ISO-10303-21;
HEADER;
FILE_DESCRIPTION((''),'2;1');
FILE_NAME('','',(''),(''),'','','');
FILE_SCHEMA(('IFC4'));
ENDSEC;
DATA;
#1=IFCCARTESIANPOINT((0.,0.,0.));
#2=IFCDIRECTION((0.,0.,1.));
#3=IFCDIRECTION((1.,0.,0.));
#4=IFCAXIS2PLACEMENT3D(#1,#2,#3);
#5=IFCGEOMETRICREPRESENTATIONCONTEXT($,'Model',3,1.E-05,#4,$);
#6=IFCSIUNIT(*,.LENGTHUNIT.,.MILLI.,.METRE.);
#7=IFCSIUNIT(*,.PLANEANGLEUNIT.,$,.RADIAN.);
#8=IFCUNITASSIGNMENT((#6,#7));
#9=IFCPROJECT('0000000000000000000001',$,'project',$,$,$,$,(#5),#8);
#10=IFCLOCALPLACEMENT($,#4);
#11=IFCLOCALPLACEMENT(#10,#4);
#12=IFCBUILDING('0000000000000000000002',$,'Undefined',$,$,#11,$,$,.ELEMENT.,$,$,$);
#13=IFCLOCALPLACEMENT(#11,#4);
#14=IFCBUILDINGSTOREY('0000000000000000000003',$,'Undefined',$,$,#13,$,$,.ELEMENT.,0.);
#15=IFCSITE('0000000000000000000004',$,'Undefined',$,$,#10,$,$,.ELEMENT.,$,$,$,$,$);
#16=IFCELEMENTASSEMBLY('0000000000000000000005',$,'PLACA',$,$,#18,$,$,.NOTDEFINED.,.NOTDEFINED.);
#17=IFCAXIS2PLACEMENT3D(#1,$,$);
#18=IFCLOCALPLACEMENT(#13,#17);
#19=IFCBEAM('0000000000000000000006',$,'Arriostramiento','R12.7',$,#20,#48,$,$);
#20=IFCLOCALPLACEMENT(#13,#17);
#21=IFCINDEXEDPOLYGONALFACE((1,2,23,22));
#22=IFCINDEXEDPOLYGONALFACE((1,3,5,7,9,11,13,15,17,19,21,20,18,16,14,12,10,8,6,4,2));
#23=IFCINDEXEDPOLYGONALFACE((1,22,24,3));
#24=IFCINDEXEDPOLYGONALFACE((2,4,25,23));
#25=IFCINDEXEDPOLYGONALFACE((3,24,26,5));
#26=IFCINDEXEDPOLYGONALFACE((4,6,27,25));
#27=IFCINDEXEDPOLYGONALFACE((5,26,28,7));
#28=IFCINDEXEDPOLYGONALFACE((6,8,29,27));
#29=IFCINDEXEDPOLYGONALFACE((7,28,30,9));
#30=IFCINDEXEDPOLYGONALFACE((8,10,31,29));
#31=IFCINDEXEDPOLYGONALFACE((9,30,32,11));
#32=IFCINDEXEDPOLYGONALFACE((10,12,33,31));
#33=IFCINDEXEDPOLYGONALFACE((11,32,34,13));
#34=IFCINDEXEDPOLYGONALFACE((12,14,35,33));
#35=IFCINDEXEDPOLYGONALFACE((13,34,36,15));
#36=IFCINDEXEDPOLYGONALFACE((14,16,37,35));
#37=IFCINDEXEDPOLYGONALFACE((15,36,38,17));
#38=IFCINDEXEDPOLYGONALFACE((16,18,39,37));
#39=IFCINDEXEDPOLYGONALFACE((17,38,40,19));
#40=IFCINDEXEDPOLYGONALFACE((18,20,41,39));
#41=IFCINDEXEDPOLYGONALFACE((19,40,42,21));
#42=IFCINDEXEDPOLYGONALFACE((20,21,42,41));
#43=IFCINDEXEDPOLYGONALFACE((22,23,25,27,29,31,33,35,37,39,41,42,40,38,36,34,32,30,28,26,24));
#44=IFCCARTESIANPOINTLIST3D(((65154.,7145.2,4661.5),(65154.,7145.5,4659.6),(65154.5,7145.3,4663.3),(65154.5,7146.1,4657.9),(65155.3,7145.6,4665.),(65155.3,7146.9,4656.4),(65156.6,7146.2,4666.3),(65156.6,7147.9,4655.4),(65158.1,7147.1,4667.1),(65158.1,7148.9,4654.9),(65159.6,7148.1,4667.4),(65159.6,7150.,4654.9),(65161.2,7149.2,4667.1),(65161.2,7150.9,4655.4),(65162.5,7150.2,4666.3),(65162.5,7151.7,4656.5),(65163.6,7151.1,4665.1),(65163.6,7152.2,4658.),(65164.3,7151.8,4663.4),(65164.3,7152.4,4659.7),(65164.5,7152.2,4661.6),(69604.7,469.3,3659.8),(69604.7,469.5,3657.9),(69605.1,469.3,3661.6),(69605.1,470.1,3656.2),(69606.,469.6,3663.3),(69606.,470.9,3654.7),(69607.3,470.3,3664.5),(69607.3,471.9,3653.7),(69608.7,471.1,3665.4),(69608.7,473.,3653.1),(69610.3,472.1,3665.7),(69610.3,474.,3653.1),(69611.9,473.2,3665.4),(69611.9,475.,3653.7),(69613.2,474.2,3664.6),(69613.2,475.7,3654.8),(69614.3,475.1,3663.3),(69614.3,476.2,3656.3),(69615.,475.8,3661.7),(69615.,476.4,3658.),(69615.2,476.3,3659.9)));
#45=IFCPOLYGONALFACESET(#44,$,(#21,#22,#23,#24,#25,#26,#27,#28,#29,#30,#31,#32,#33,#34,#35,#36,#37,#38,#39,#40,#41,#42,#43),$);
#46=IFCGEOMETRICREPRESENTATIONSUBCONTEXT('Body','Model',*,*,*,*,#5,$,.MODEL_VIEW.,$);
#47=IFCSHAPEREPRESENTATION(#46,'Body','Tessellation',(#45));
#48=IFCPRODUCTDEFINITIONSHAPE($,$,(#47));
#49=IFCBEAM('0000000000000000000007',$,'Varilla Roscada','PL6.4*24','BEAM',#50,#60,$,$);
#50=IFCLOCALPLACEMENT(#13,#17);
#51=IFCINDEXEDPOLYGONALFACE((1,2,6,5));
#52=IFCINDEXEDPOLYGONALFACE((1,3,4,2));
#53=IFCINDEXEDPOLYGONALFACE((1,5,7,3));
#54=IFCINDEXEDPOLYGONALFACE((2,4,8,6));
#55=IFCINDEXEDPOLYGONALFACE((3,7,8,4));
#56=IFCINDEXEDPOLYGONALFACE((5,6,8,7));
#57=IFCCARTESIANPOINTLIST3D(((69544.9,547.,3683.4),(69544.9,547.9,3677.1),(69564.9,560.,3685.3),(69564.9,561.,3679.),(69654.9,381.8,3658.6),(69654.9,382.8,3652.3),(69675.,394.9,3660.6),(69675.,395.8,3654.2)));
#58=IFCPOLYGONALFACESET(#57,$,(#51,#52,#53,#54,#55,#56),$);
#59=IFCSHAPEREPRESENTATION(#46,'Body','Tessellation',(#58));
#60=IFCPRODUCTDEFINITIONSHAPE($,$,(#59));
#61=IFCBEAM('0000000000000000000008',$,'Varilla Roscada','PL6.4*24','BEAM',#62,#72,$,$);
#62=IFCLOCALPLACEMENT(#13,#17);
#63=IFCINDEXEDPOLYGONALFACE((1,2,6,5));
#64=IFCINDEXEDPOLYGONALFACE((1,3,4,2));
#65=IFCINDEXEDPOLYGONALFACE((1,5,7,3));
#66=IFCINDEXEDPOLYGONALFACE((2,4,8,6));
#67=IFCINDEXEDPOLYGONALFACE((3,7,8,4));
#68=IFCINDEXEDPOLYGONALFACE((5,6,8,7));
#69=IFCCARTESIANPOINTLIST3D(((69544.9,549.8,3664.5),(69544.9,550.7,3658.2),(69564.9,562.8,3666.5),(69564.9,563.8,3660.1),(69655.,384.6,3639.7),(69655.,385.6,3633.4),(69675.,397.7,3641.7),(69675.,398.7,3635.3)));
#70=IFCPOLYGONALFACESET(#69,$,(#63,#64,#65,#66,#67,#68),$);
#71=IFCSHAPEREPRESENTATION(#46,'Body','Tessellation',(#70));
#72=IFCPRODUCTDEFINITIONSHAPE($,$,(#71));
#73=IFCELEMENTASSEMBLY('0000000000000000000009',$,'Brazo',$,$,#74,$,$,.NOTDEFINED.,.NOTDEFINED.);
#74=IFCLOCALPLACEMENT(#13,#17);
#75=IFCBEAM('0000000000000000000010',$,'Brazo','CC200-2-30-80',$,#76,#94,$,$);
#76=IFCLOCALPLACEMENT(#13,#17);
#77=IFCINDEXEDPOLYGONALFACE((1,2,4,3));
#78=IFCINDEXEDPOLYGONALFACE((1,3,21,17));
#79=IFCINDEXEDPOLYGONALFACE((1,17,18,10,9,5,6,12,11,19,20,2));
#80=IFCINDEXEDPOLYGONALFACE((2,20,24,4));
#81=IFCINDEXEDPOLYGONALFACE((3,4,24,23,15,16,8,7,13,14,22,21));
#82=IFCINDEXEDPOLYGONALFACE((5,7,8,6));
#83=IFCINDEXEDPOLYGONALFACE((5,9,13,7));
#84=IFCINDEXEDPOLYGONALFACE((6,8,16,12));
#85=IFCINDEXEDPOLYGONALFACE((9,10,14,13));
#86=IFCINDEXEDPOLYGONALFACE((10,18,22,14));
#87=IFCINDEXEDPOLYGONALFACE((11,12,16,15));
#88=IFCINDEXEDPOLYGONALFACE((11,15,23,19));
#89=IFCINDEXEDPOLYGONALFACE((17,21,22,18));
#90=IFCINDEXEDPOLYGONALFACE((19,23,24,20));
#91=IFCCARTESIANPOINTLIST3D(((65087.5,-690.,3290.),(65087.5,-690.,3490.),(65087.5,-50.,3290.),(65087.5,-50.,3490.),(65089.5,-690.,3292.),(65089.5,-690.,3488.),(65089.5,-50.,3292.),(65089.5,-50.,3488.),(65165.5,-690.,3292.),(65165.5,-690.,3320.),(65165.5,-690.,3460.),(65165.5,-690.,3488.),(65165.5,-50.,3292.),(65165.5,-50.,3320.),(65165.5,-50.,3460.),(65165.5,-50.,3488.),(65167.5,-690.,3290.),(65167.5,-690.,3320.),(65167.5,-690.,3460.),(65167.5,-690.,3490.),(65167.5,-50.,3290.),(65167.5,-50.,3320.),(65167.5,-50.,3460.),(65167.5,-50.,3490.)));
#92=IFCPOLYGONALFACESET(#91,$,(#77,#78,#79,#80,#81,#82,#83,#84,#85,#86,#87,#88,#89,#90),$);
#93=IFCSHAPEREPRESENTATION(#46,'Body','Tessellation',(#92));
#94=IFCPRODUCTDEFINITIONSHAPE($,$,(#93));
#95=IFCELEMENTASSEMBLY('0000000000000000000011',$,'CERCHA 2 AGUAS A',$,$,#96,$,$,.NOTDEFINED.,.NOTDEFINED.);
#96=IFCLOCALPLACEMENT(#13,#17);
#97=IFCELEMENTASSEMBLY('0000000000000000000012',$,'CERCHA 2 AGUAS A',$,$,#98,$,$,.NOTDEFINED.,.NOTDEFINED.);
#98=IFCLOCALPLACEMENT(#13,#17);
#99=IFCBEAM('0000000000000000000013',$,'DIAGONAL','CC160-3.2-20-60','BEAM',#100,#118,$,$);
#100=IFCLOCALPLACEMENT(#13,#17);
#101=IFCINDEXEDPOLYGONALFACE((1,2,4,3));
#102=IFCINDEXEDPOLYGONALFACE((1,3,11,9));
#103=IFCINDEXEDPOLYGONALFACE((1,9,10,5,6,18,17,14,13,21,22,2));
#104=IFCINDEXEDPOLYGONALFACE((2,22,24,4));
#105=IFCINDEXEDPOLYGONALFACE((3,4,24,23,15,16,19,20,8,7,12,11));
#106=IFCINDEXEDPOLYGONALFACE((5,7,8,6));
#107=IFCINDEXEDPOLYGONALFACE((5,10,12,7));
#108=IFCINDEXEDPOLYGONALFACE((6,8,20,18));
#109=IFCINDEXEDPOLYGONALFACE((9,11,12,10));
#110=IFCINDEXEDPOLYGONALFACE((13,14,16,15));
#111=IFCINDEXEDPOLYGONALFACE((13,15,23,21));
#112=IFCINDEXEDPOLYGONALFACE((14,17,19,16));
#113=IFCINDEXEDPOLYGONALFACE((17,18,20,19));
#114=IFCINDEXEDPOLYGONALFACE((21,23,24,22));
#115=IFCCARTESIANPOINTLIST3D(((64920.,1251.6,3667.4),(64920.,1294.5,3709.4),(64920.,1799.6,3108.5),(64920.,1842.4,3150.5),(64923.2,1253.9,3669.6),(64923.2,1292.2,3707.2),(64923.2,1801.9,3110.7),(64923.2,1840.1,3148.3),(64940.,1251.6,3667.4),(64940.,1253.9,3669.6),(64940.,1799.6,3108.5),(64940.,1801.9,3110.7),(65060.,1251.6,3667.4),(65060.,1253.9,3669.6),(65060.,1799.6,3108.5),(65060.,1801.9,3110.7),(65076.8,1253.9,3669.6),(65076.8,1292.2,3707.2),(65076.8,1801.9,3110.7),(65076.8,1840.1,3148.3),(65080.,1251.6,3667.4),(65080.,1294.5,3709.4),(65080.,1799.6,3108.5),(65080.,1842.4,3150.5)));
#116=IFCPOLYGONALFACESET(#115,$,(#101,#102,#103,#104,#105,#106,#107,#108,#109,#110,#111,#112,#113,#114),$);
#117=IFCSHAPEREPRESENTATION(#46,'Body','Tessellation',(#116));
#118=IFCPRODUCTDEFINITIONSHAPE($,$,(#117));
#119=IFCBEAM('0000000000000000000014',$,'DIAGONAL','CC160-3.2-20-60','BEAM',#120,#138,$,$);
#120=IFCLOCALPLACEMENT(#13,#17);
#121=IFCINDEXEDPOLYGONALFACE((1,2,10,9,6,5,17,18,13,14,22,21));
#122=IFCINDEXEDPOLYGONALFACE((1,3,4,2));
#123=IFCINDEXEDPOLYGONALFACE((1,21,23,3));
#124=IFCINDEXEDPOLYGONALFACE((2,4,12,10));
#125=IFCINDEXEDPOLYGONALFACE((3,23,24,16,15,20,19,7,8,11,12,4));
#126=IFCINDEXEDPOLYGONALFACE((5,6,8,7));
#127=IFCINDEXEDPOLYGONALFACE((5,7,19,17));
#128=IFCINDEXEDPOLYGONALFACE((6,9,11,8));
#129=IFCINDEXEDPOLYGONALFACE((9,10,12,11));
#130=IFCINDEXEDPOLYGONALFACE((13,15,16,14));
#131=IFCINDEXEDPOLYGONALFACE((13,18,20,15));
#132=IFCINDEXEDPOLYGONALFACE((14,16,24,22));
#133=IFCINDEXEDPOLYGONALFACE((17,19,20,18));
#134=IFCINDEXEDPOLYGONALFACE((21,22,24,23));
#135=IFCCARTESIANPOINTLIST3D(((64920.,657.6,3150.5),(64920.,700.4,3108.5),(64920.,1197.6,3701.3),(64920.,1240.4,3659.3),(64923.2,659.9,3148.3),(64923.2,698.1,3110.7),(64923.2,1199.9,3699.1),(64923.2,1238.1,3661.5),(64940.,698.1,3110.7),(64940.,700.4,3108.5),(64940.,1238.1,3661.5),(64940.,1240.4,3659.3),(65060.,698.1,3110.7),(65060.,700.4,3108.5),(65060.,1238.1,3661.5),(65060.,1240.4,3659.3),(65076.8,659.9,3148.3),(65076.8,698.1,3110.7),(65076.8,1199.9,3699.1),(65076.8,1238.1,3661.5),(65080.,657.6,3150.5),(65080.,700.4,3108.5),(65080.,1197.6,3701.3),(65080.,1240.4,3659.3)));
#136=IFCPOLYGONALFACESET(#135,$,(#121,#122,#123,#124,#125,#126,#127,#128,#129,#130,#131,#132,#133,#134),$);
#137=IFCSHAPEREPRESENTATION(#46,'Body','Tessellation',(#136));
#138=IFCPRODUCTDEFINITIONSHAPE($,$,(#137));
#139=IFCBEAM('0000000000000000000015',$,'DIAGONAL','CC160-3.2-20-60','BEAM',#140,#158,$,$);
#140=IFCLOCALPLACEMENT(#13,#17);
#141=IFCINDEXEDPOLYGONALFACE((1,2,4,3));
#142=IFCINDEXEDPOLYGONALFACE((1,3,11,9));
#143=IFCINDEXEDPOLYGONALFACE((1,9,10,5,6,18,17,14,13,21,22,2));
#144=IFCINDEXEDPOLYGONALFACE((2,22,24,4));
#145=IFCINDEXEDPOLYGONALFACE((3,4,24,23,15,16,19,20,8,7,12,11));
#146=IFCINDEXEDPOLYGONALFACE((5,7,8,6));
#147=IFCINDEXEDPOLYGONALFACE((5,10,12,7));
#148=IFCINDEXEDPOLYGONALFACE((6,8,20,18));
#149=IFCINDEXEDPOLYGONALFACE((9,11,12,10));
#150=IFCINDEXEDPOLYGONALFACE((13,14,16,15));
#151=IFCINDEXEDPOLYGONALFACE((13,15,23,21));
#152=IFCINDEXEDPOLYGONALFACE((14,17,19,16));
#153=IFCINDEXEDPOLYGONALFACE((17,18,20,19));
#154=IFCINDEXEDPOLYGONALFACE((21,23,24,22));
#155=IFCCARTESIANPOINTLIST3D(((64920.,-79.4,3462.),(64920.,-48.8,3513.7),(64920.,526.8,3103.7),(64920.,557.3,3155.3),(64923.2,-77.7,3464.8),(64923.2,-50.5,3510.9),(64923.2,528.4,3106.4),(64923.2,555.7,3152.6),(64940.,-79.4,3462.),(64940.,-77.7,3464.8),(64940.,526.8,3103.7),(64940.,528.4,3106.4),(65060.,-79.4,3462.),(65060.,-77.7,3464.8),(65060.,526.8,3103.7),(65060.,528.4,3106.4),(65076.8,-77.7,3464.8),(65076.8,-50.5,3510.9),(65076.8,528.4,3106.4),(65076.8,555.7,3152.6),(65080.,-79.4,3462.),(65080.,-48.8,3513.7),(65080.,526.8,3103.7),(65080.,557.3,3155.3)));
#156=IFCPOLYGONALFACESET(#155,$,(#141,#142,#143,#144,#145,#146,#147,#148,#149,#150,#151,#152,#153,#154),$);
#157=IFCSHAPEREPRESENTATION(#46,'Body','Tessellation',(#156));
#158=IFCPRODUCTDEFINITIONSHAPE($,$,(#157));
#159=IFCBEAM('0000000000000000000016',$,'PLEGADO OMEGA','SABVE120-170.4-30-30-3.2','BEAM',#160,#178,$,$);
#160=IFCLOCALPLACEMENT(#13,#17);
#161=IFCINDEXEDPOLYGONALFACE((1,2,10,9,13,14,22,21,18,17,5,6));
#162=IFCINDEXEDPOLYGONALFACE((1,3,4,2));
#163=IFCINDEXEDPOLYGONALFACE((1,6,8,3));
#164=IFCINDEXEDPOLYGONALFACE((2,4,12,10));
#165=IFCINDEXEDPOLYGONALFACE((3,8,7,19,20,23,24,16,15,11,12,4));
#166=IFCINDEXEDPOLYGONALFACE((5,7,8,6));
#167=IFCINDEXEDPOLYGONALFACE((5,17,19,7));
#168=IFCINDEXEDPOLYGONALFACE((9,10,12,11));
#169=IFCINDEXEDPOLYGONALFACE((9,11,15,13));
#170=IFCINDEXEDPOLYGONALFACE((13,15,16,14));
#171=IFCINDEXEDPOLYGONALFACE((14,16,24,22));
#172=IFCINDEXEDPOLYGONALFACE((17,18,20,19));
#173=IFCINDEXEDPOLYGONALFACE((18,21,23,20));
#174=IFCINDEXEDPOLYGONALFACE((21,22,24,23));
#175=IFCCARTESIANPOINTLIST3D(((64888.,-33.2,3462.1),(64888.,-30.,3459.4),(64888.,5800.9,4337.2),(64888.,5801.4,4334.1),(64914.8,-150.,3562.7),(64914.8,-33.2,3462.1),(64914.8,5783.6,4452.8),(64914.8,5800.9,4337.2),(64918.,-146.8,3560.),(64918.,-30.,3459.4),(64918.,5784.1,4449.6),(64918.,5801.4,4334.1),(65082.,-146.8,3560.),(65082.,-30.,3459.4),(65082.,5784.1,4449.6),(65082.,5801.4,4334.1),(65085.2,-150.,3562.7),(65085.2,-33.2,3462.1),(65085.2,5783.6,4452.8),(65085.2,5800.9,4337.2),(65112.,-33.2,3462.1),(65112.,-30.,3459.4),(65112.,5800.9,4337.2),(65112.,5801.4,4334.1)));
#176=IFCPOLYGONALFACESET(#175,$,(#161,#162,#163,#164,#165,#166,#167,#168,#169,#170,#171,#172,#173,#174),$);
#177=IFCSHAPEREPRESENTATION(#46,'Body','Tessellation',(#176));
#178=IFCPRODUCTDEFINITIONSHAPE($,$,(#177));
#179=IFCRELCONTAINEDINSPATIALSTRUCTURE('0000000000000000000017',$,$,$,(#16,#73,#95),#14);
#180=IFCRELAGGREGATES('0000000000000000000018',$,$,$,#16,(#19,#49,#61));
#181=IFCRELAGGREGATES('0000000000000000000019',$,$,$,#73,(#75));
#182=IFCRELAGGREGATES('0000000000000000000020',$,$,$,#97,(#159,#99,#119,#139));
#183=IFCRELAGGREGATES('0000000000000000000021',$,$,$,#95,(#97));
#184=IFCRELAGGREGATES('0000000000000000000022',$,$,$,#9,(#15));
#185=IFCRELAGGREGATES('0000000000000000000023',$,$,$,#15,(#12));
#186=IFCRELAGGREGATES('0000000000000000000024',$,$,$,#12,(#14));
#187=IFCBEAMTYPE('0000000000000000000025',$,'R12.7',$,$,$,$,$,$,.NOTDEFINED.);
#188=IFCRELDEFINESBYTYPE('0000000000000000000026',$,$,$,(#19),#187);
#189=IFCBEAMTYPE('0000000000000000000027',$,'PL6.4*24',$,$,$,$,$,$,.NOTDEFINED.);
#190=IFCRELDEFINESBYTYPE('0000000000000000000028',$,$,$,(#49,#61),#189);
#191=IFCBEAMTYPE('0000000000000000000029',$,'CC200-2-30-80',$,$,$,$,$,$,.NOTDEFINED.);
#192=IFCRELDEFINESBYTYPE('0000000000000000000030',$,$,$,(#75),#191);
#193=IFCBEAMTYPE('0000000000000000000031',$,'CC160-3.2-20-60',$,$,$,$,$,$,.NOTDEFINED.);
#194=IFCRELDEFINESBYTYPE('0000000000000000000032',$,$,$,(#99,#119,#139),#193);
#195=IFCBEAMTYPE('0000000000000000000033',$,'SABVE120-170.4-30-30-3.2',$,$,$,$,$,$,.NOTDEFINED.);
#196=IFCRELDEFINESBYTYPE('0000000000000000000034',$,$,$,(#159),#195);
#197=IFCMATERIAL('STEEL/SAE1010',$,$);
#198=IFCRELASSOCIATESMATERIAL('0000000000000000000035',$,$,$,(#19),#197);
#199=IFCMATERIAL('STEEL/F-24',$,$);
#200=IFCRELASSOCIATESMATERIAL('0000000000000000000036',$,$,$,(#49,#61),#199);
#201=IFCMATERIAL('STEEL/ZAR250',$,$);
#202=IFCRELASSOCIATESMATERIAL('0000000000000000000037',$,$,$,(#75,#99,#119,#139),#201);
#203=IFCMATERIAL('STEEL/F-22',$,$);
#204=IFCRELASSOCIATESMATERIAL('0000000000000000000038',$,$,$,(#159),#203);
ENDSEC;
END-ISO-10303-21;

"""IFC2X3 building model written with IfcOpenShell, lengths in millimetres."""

from ifc_helpers import new_model, si_unit, frame, origin_with_axes, origin_2d_with_axis, place, context, subcontext, project, spatial, polyline, rectangle, circle, c_section, outline, extrude, clip, halfspace, material, type_object, element, aggregate, save


model = new_model("IFC2X3")

# Units and contexts
model_context = context("Model", 3, precision=1e-05, world=origin_with_axes())
body_context = subcontext(model_context, "Body", "Model", "MODEL_VIEW")
ifc_project = project(units=[si_unit("LENGTHUNIT", "METRE", prefix="MILLI"), si_unit("PLANEANGLEUNIT", "RADIAN")], contexts=[model_context])

# Site, building, storey
site_placement = place(None, origin_with_axes())
site = spatial("IfcSite", under=ifc_project, at=site_placement, Name="Undefined", CompositionType="ELEMENT")
building_placement = place(site_placement, origin_with_axes())
building = spatial("IfcBuilding", under=site, at=building_placement, Name="Undefined", CompositionType="ELEMENT")
storey_placement = place(building_placement, origin_with_axes())
storey = spatial("IfcBuildingStorey", under=building, at=storey_placement, Name="Undefined", CompositionType="ELEMENT", Elevation=0.0)

# Element assembly, beams
assembly_1_placement = place(storey_placement, origin_with_axes())
assembly_1 = element("IfcElementAssembly", 1, at=assembly_1_placement, inside=storey, Name="PLACA", AssemblyPlace="NOTDEFINED", PredefinedType="NOTDEFINED")
ifc_material_1 = material(Name="STEEL/SAE1010")
beam_type_1 = type_object("IfcBeamType", Name="R12.7", PredefinedType="NOTDEFINED")
beam_1_placement = place(assembly_1_placement, frame((69609.9, 472.8, 3659.4), z_axis=(0.00002, -0.148375, 0.988931), x_axis=(-0.550431, 0.825638, 0.123886)))
beam_1 = element("IfcBeam", 2, at=beam_1_placement, type_object=beam_type_1, material=ifc_material_1, Name="Arriostramiento", Description="R12.7", context=body_context, shape_type="SweptSolid", body=[
    extrude(circle(Radius=6.3, at=origin_2d_with_axis()), frame((8085.8, 0.0, 0.0), z_axis=(-1.0, 0.0, 0.0), x_axis=(0.0, -1.0, 0.0)), (0.0, 0.0, 1.0), 8085.8),
])
ifc_material_2 = material(Name="STEEL/F-24")
beam_type_2 = type_object("IfcBeamType", Name="PL6.4*24", PredefinedType="NOTDEFINED")
beam_2_placement = place(assembly_1_placement, frame((69554.9, 554.0, 3681.2), z_axis=(-0.834881, -0.544341, -0.081653), x_axis=(0.550431, -0.825638, -0.123885)))
beam_2 = element("IfcBeam", 3, at=beam_2_placement, type_object=beam_type_2, material=ifc_material_2, Name="Varilla Roscada", Description="PL6.4*24", ObjectType="BEAM", context=body_context, shape_type="SweptSolid", body=[
    extrude(rectangle(XDim=6.4, YDim=24.0, at=origin_2d_with_axis()), frame((200.0, 0.0, 0.0), z_axis=(-1.0, 0.0, 0.0), x_axis=(0.0, -1.0, 0.0)), (0.0, 0.0, 1.0), 200.0),
])
beam_3_placement = place(assembly_1_placement, frame((69554.9, 556.8, 3662.3), z_axis=(-0.834881, -0.544341, -0.081653), x_axis=(0.550431, -0.825638, -0.123885)))
beam_3 = element("IfcBeam", 4, at=beam_3_placement, type_object=beam_type_2, material=ifc_material_2, Name="Varilla Roscada", Description="PL6.4*24", ObjectType="BEAM", context=body_context, shape_type="SweptSolid", body=[
    extrude(rectangle(XDim=6.4, YDim=24.0, at=origin_2d_with_axis()), frame((200.0, 0.0, 0.0), z_axis=(-1.0, 0.0, 0.0), x_axis=(0.0, -1.0, 0.0)), (0.0, 0.0, 1.0), 200.0),
])
aggregate(assembly_1, [beam_1, beam_2, beam_3])

# Element assembly, beam
assembly_2_placement = place(storey_placement, origin_with_axes())
assembly_2 = element("IfcElementAssembly", 5, at=assembly_2_placement, inside=storey, Name="Brazo", AssemblyPlace="NOTDEFINED", PredefinedType="NOTDEFINED")
ifc_material_3 = material(Name="STEEL/ZAR250")
beam_type_3 = type_object("IfcBeamType", Name="CC200-2-30-80", PredefinedType="NOTDEFINED")
beam_4_placement = place(assembly_2_placement, frame((65127.5, -50.0, 3390.0), z_axis=(0.0, 0.000005, -1.0), x_axis=(-0.000004, -1.0, -0.000005)))
beam_4 = element("IfcBeam", 6, at=beam_4_placement, type_object=beam_type_3, material=ifc_material_3, Name="Brazo", Description="CC200-2-30-80", context=body_context, shape_type="SweptSolid", body=[
    extrude(c_section(Depth=200.0, Width=80.0, WallThickness=2.0, Girth=30.0, at=origin_2d_with_axis()), frame((640.0, 0.0, 0.0), z_axis=(-1.0, 0.0, 0.0), x_axis=(0.0, -1.0, 0.0)), (0.0, 0.0, 1.0), 640.0),
])

# Element assemblies, beams
assembly_3_placement = place(storey_placement, origin_with_axes())
assembly_3 = element("IfcElementAssembly", 7, at=assembly_3_placement, inside=storey, Name="CERCHA 2 AGUAS A", AssemblyPlace="NOTDEFINED", PredefinedType="NOTDEFINED")
assembly_4_placement = place(assembly_3_placement, origin_with_axes())
assembly_4 = element("IfcElementAssembly", 8, at=assembly_4_placement, Name="CERCHA 2 AGUAS A", AssemblyPlace="NOTDEFINED", PredefinedType="NOTDEFINED")
beam_type_4 = type_object("IfcBeamType", Name="CC160-3.2-20-60", PredefinedType="NOTDEFINED")
beam_5_placement = place(assembly_4_placement, frame((65000.0, 1273.1, 3688.4), z_axis=(1.0, 0.0, 0.0), x_axis=(0.0, 0.700071, -0.714073)))
beam_5 = element("IfcBeam", 9, at=beam_5_placement, type_object=beam_type_4, material=ifc_material_3, Name="DIAGONAL", Description="CC160-3.2-20-60", ObjectType="BEAM", context=body_context, shape_type="SweptSolid", body=[
    extrude(c_section(Depth=160.0, Width=60.0, WallThickness=3.2, Girth=20.0, at=origin_2d_with_axis()), frame((782.7, 0.0, 0.0), z_axis=(-1.0, 0.0, 0.0), x_axis=(0.0, -1.0, 0.0)), (0.0, 0.0, 1.0), 782.7),
])
beam_6_placement = place(assembly_4_placement, frame((65000.0, 679.0, 3129.5), z_axis=(1.0, 0.0, 0.0), x_axis=(0.0, 0.700071, 0.714073)))
beam_6 = element("IfcBeam", 10, at=beam_6_placement, type_object=beam_type_4, material=ifc_material_3, Name="DIAGONAL", Description="CC160-3.2-20-60", ObjectType="BEAM", context=body_context, shape_type="SweptSolid", body=[
    extrude(c_section(Depth=160.0, Width=60.0, WallThickness=3.2, Girth=20.0, at=origin_2d_with_axis()), frame((771.3, 0.0, 0.0), z_axis=(-1.0, 0.0, 0.0), x_axis=(0.0, -1.0, 0.0)), (0.0, 0.0, 1.0), 771.3),
])
beam_7_placement = place(assembly_4_placement, frame((65000.0, -64.1, 3487.8), z_axis=(1.0, 0.0, 0.0), x_axis=(0.0, 0.860828, -0.508895)))
beam_7 = element("IfcBeam", 11, at=beam_7_placement, type_object=beam_type_4, material=ifc_material_3, Name="DIAGONAL", Description="CC160-3.2-20-60", ObjectType="BEAM", context=body_context, shape_type="SweptSolid", body=[
    extrude(c_section(Depth=160.0, Width=60.0, WallThickness=3.2, Girth=20.0, at=origin_2d_with_axis()), frame((704.1, 0.0, 0.0), z_axis=(-1.0, 0.0, 0.0), x_axis=(0.0, -1.0, 0.0)), (0.0, 0.0, 1.0), 704.1),
])
ifc_material_4 = material(Name="STEEL/F-22")
beam_type_5 = type_object("IfcBeamType", Name="SABVE120-170.4-30-30-3.2", PredefinedType="NOTDEFINED")
beam_8_placement = place(assembly_4_placement, frame((65000.0, -141.1, 3503.4), z_axis=(0.0, 0.14834, -0.988936), x_axis=(0.0, 0.988936, 0.14834)))
beam_8 = element("IfcBeam", 12, at=beam_8_placement, type_object=beam_type_5, material=ifc_material_4, Name="PLEGADO OMEGA", Description="SABVE120-170.4-30-30-3.2", ObjectType="BEAM", context=body_context, shape_type="Clipping", body=[
    clip(extrude(outline(polyline([(82.0, 60.0), (112.0, 60.0), (112.0, 56.8), (85.2, 56.8), (85.2, -60.0), (-85.2, -60.0), (-85.2, 56.8), (-112.0, 56.8), (-112.0, 60.0), (-82.0, 60.0), (-82.0, -56.8), (82.0, -56.8), (82.0, 60.0)])), frame((6000.0, 0.0, 0.0), z_axis=(-1.0, 0.0, 0.0), x_axis=(0.0, -1.0, 0.0)), (0.0, 0.0, 1.0), 6033.8), halfspace(frame((0.0, 0.0, -60.0), z_axis=(-0.757741, 0.0, 0.652555), x_axis=(0.0, 1.0, 0.0)), False)),
])

aggregate(assembly_2, [beam_4])
aggregate(assembly_4, [beam_8, beam_5, beam_6, beam_7])

aggregate(assembly_3, [assembly_4])

save(model, "model.ifc")
